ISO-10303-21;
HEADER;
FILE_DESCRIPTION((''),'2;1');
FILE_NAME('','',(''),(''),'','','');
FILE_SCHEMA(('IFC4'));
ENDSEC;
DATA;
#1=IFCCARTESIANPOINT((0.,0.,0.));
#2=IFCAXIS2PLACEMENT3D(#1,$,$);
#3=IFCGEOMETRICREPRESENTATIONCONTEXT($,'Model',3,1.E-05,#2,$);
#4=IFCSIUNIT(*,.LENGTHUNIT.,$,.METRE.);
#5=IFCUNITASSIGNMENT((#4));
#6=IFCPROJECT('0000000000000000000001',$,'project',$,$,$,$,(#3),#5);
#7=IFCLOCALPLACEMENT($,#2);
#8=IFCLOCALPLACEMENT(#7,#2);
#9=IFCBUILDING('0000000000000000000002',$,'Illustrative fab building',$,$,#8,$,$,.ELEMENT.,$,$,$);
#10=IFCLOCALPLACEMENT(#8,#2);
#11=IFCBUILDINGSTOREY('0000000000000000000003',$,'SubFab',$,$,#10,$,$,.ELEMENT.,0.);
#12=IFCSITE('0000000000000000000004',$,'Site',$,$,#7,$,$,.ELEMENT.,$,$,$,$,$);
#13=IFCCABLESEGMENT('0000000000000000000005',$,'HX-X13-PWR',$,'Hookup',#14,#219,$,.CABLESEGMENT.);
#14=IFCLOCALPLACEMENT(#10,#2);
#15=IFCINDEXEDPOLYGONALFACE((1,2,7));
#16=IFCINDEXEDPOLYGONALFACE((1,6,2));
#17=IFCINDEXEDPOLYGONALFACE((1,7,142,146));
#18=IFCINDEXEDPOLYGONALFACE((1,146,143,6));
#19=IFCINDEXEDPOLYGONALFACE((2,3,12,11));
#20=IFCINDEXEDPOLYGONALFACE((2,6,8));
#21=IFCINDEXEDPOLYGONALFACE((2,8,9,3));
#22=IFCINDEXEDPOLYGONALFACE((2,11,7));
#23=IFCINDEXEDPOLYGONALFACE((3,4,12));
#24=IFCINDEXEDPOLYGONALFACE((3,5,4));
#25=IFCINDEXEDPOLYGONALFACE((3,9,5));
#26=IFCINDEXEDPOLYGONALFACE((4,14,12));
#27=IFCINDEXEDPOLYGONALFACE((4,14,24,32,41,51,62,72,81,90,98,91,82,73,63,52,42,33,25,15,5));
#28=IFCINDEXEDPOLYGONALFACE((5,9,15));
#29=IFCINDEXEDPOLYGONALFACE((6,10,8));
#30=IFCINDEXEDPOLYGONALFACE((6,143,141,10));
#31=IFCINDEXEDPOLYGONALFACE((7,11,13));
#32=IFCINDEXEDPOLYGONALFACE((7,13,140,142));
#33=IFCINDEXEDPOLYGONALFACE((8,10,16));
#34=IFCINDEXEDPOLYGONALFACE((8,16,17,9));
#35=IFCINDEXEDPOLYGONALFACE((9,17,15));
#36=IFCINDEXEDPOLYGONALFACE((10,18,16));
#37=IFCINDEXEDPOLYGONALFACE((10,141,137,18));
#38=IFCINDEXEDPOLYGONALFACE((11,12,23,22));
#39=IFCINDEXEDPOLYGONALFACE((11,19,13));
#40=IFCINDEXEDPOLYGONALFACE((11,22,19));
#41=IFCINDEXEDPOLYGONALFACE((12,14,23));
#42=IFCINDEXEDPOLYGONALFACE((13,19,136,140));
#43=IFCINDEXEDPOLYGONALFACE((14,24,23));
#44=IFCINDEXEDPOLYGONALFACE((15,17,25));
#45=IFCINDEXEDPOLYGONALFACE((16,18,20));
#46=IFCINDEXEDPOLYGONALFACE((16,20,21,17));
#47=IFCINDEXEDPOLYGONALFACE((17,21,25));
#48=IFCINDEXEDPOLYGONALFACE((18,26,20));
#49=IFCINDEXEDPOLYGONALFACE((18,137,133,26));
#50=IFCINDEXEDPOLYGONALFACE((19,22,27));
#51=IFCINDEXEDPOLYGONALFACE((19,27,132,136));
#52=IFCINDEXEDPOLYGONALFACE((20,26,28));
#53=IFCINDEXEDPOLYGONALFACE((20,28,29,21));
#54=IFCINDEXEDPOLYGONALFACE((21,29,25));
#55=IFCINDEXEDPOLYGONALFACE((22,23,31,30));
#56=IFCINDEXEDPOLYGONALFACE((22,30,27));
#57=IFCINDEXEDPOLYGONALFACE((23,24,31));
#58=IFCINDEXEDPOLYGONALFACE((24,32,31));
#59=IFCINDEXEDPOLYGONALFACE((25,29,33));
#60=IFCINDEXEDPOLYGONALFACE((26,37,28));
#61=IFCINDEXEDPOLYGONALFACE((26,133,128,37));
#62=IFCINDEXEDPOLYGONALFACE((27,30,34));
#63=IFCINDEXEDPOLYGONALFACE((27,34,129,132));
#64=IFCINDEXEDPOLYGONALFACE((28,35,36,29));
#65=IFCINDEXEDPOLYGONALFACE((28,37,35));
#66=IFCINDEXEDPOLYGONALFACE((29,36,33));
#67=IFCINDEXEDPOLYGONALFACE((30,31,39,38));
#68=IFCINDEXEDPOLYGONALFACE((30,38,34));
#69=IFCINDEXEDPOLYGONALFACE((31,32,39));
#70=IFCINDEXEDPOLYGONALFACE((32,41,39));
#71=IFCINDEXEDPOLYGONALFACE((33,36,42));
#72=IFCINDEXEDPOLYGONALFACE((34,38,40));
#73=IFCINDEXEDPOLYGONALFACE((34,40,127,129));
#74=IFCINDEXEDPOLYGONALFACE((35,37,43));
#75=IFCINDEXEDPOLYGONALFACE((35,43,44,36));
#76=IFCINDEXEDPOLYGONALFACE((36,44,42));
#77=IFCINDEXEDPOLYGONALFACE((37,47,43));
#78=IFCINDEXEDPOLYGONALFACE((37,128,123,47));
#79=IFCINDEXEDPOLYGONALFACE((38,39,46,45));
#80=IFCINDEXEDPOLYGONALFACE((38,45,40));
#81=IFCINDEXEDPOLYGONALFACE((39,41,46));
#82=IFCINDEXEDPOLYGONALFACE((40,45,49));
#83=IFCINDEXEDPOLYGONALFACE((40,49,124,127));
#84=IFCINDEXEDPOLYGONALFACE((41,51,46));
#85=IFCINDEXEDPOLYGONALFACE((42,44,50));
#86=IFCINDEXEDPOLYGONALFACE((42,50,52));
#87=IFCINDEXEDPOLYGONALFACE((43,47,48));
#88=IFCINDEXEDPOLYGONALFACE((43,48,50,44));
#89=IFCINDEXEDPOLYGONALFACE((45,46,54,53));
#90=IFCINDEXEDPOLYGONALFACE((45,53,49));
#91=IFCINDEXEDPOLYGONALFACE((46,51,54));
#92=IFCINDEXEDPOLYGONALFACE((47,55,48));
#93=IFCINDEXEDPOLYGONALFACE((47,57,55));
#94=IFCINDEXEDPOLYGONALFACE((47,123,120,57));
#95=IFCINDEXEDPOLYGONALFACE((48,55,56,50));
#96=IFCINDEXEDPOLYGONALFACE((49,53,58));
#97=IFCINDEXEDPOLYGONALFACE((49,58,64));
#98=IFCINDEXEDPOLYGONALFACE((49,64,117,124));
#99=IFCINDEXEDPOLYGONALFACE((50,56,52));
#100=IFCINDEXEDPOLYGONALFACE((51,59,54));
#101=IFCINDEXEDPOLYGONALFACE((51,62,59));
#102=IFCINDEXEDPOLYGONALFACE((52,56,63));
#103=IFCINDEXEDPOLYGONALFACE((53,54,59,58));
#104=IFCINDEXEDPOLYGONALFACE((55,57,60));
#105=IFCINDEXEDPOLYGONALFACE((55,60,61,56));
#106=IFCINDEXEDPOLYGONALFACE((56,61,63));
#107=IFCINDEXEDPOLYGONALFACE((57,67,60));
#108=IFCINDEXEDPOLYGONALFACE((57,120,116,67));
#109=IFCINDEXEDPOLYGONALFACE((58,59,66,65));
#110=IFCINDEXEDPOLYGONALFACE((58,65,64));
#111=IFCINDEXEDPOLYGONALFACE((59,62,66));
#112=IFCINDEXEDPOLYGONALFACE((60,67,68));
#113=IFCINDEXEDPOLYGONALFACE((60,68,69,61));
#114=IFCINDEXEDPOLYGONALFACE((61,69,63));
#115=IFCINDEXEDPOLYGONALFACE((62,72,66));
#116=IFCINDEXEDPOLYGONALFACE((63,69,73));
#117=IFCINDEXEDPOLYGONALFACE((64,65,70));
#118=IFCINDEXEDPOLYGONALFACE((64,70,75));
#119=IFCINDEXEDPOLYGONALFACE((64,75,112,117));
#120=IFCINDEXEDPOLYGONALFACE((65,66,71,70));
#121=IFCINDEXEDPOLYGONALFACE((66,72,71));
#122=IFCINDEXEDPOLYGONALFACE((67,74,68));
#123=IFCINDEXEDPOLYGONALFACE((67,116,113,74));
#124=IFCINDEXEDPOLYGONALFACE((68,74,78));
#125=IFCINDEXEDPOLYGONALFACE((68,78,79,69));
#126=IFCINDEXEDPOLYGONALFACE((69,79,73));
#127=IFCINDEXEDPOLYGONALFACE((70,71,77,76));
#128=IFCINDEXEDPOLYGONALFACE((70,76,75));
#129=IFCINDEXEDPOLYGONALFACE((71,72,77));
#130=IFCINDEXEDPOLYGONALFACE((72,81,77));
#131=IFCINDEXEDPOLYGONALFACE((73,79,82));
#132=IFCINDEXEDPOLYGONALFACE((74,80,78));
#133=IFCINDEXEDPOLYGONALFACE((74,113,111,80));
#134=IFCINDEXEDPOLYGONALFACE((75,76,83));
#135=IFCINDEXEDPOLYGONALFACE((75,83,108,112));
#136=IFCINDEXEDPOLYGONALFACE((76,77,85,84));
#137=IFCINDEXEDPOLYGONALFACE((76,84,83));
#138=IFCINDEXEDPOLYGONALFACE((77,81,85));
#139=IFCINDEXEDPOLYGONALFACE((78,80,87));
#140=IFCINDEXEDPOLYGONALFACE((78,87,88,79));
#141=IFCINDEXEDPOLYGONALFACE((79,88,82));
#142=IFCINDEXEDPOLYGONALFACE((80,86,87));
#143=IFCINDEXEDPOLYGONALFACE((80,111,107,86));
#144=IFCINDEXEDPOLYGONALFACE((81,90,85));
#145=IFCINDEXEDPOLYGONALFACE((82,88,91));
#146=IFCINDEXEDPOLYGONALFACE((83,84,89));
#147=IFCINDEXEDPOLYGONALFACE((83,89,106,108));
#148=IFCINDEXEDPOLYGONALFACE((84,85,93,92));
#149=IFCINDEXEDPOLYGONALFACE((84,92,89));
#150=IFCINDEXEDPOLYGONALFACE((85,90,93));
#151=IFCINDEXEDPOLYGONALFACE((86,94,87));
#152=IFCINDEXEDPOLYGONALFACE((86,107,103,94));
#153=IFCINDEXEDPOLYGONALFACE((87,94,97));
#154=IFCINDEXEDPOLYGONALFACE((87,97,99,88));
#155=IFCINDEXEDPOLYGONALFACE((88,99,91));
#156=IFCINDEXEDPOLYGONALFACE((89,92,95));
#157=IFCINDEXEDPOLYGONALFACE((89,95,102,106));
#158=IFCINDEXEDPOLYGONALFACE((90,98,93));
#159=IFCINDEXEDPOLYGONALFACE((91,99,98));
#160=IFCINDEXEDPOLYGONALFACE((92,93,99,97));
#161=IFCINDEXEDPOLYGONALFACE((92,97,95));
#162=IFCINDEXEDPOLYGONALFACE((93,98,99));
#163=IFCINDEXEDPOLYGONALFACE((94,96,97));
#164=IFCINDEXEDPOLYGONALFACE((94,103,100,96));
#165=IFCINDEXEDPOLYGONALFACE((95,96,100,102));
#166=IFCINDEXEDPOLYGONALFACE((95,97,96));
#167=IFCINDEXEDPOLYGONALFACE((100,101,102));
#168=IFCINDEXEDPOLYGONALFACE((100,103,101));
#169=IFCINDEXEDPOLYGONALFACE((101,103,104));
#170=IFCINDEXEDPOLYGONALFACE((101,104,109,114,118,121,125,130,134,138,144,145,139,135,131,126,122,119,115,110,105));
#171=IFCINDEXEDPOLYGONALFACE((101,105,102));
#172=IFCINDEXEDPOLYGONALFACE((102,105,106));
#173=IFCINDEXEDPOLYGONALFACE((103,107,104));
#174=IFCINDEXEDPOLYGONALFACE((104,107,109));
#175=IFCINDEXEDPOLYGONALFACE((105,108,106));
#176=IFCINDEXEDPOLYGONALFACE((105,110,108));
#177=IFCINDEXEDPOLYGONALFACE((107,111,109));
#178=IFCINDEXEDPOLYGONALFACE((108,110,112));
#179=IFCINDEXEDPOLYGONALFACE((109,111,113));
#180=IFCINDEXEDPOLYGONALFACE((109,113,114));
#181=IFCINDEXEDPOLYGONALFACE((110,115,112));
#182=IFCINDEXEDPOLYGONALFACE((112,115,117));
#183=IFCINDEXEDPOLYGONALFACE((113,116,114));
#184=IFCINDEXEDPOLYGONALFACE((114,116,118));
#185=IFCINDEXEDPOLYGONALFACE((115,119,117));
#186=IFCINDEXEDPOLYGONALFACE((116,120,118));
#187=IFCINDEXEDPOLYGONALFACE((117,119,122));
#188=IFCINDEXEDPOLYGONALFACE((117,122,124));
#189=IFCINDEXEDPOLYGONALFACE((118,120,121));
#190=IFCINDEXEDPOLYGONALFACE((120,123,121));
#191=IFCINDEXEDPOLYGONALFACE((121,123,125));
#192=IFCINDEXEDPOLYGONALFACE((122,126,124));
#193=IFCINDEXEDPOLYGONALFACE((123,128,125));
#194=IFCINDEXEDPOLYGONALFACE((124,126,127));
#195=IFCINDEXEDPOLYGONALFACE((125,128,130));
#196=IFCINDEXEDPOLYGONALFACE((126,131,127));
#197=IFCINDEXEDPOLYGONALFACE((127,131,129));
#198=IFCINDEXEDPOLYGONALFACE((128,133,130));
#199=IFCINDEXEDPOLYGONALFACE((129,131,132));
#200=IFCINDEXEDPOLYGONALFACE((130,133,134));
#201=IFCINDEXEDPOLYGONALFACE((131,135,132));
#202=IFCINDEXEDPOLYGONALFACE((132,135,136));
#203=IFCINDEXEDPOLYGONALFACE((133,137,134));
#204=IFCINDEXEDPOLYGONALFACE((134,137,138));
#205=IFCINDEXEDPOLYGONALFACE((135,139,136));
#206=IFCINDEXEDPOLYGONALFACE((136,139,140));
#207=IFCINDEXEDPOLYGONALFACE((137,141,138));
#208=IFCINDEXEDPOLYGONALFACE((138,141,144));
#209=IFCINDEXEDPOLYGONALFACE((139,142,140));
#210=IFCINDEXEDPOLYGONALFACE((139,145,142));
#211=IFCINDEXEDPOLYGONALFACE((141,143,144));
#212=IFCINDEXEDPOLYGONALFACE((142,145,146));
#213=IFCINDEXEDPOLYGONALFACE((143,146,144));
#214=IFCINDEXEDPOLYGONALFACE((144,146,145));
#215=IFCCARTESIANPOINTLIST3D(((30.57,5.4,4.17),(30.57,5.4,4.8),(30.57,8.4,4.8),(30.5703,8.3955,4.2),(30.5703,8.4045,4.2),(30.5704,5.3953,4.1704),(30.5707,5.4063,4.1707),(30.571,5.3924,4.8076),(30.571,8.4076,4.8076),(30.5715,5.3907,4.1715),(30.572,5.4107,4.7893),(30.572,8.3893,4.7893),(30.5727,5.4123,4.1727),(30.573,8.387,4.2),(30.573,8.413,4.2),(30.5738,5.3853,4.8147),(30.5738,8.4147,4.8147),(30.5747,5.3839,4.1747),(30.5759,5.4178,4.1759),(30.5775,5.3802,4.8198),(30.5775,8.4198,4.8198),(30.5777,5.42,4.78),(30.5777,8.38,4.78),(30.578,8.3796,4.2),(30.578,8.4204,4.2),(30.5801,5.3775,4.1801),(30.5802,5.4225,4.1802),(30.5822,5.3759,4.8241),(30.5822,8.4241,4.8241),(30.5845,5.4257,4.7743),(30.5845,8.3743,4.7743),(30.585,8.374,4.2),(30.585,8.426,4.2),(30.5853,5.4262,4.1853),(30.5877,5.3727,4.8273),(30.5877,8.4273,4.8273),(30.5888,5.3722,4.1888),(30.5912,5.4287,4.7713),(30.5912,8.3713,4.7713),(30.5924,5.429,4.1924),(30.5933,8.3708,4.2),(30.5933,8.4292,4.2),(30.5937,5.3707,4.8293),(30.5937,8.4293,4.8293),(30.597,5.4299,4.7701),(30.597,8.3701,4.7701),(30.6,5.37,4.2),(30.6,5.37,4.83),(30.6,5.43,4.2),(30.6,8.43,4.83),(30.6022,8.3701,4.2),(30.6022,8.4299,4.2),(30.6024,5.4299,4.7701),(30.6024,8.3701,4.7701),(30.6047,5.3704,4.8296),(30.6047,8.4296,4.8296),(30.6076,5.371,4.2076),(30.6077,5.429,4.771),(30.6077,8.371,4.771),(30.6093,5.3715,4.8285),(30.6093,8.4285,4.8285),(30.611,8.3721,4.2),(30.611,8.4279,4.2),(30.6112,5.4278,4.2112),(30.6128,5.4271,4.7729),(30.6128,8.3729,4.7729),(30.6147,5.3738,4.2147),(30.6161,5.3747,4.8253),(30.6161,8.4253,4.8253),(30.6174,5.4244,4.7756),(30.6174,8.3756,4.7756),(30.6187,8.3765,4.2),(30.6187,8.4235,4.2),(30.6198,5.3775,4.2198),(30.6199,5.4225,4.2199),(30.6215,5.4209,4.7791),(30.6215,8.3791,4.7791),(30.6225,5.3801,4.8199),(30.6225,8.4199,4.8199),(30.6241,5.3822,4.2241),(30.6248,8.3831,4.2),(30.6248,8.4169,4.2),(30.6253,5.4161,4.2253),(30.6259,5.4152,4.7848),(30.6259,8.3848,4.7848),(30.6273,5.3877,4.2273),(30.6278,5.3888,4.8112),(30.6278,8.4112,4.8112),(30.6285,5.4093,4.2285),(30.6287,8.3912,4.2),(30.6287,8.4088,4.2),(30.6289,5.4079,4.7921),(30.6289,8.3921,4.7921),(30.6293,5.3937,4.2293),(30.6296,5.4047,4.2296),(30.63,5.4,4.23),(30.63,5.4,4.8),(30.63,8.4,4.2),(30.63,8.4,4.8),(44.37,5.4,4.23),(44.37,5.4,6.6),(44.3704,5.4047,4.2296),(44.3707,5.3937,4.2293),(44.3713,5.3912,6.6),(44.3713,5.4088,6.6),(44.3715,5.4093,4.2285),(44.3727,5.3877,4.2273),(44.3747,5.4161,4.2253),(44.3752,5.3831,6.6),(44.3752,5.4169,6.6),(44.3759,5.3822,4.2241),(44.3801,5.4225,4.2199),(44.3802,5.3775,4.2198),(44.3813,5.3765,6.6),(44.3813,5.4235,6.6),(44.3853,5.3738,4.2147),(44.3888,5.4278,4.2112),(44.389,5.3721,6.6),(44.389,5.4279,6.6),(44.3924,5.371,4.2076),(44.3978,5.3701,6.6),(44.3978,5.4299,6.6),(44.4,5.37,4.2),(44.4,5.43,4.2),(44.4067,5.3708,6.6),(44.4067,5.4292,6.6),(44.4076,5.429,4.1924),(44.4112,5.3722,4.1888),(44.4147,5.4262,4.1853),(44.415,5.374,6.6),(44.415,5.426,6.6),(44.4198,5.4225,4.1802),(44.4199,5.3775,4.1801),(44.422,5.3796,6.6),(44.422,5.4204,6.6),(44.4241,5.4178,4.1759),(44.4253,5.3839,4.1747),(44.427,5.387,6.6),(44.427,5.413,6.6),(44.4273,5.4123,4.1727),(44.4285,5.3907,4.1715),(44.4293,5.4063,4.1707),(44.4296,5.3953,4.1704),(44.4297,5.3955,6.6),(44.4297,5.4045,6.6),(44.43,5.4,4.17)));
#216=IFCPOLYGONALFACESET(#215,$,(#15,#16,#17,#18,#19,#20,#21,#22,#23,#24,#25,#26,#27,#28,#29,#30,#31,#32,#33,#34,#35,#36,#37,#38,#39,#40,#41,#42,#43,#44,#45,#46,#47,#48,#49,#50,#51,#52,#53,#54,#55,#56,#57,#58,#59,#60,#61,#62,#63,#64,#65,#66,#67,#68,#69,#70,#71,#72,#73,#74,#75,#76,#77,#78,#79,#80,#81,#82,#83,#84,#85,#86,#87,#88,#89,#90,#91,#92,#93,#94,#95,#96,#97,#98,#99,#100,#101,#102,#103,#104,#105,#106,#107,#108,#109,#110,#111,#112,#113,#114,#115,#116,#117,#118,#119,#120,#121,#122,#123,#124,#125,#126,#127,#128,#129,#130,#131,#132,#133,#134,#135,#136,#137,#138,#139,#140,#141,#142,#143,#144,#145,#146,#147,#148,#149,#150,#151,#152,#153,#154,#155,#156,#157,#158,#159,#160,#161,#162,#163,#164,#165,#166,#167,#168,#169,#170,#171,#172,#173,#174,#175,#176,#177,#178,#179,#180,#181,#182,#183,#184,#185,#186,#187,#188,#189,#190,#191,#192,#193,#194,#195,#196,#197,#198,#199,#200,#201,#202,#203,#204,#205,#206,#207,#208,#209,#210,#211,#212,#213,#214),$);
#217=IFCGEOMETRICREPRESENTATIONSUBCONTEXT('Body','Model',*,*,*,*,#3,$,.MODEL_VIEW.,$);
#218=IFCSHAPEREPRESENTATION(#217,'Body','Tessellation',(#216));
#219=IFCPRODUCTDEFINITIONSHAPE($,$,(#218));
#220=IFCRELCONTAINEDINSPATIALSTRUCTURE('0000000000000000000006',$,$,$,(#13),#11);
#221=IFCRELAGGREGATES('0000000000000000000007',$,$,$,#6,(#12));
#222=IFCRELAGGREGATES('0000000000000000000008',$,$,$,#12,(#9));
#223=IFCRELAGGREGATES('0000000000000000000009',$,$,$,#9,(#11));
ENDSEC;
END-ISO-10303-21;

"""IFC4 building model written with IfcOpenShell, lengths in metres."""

from ifc_helpers import new_model, entity, si_unit, origin, place, context, subcontext, project, spatial, element, save


model = new_model("IFC4")

# Units and contexts
model_context = context("Model", 3, precision=1e-05, world=origin())
body_context = subcontext(model_context, "Body", "Model", "MODEL_VIEW")
ifc_project = project(units=[si_unit("LENGTHUNIT", "METRE")], contexts=[model_context])

# Site, building, storey
site_placement = place(None, origin())
site = spatial("IfcSite", under=ifc_project, at=site_placement, Name="Site", CompositionType="ELEMENT")
building_placement = place(site_placement, origin())
building = spatial("IfcBuilding", under=site, at=building_placement, Name="Illustrative fab building", CompositionType="ELEMENT")
storey_placement = place(building_placement, origin())
storey = spatial("IfcBuildingStorey", under=building, at=storey_placement, Name="SubFab", CompositionType="ELEMENT", Elevation=0.0)

# Cable segment
cable_segment_1_placement = place(storey_placement, origin())
element("IfcCableSegment", 1, at=cable_segment_1_placement, inside=storey, Name="HX-X13-PWR", ObjectType="Hookup", PredefinedType="CABLESEGMENT", context=body_context, shape_type="AdvancedSweptSolid", body=[
    entity("IfcSweptDiskSolid", entity("IfcPolyline", [entity("IfcCartesianPoint", [30.6, 8.4, 4.2]), entity("IfcCartesianPoint", [30.6, 8.4, 4.8]), entity("IfcCartesianPoint", [30.6, 5.4, 4.8]), entity("IfcCartesianPoint", [30.6, 5.4, 4.2]), entity("IfcCartesianPoint", [44.4, 5.4, 4.2]), entity("IfcCartesianPoint", [44.4, 5.4, 6.6])]), 0.03),
])

save(model, "model.ifc")
